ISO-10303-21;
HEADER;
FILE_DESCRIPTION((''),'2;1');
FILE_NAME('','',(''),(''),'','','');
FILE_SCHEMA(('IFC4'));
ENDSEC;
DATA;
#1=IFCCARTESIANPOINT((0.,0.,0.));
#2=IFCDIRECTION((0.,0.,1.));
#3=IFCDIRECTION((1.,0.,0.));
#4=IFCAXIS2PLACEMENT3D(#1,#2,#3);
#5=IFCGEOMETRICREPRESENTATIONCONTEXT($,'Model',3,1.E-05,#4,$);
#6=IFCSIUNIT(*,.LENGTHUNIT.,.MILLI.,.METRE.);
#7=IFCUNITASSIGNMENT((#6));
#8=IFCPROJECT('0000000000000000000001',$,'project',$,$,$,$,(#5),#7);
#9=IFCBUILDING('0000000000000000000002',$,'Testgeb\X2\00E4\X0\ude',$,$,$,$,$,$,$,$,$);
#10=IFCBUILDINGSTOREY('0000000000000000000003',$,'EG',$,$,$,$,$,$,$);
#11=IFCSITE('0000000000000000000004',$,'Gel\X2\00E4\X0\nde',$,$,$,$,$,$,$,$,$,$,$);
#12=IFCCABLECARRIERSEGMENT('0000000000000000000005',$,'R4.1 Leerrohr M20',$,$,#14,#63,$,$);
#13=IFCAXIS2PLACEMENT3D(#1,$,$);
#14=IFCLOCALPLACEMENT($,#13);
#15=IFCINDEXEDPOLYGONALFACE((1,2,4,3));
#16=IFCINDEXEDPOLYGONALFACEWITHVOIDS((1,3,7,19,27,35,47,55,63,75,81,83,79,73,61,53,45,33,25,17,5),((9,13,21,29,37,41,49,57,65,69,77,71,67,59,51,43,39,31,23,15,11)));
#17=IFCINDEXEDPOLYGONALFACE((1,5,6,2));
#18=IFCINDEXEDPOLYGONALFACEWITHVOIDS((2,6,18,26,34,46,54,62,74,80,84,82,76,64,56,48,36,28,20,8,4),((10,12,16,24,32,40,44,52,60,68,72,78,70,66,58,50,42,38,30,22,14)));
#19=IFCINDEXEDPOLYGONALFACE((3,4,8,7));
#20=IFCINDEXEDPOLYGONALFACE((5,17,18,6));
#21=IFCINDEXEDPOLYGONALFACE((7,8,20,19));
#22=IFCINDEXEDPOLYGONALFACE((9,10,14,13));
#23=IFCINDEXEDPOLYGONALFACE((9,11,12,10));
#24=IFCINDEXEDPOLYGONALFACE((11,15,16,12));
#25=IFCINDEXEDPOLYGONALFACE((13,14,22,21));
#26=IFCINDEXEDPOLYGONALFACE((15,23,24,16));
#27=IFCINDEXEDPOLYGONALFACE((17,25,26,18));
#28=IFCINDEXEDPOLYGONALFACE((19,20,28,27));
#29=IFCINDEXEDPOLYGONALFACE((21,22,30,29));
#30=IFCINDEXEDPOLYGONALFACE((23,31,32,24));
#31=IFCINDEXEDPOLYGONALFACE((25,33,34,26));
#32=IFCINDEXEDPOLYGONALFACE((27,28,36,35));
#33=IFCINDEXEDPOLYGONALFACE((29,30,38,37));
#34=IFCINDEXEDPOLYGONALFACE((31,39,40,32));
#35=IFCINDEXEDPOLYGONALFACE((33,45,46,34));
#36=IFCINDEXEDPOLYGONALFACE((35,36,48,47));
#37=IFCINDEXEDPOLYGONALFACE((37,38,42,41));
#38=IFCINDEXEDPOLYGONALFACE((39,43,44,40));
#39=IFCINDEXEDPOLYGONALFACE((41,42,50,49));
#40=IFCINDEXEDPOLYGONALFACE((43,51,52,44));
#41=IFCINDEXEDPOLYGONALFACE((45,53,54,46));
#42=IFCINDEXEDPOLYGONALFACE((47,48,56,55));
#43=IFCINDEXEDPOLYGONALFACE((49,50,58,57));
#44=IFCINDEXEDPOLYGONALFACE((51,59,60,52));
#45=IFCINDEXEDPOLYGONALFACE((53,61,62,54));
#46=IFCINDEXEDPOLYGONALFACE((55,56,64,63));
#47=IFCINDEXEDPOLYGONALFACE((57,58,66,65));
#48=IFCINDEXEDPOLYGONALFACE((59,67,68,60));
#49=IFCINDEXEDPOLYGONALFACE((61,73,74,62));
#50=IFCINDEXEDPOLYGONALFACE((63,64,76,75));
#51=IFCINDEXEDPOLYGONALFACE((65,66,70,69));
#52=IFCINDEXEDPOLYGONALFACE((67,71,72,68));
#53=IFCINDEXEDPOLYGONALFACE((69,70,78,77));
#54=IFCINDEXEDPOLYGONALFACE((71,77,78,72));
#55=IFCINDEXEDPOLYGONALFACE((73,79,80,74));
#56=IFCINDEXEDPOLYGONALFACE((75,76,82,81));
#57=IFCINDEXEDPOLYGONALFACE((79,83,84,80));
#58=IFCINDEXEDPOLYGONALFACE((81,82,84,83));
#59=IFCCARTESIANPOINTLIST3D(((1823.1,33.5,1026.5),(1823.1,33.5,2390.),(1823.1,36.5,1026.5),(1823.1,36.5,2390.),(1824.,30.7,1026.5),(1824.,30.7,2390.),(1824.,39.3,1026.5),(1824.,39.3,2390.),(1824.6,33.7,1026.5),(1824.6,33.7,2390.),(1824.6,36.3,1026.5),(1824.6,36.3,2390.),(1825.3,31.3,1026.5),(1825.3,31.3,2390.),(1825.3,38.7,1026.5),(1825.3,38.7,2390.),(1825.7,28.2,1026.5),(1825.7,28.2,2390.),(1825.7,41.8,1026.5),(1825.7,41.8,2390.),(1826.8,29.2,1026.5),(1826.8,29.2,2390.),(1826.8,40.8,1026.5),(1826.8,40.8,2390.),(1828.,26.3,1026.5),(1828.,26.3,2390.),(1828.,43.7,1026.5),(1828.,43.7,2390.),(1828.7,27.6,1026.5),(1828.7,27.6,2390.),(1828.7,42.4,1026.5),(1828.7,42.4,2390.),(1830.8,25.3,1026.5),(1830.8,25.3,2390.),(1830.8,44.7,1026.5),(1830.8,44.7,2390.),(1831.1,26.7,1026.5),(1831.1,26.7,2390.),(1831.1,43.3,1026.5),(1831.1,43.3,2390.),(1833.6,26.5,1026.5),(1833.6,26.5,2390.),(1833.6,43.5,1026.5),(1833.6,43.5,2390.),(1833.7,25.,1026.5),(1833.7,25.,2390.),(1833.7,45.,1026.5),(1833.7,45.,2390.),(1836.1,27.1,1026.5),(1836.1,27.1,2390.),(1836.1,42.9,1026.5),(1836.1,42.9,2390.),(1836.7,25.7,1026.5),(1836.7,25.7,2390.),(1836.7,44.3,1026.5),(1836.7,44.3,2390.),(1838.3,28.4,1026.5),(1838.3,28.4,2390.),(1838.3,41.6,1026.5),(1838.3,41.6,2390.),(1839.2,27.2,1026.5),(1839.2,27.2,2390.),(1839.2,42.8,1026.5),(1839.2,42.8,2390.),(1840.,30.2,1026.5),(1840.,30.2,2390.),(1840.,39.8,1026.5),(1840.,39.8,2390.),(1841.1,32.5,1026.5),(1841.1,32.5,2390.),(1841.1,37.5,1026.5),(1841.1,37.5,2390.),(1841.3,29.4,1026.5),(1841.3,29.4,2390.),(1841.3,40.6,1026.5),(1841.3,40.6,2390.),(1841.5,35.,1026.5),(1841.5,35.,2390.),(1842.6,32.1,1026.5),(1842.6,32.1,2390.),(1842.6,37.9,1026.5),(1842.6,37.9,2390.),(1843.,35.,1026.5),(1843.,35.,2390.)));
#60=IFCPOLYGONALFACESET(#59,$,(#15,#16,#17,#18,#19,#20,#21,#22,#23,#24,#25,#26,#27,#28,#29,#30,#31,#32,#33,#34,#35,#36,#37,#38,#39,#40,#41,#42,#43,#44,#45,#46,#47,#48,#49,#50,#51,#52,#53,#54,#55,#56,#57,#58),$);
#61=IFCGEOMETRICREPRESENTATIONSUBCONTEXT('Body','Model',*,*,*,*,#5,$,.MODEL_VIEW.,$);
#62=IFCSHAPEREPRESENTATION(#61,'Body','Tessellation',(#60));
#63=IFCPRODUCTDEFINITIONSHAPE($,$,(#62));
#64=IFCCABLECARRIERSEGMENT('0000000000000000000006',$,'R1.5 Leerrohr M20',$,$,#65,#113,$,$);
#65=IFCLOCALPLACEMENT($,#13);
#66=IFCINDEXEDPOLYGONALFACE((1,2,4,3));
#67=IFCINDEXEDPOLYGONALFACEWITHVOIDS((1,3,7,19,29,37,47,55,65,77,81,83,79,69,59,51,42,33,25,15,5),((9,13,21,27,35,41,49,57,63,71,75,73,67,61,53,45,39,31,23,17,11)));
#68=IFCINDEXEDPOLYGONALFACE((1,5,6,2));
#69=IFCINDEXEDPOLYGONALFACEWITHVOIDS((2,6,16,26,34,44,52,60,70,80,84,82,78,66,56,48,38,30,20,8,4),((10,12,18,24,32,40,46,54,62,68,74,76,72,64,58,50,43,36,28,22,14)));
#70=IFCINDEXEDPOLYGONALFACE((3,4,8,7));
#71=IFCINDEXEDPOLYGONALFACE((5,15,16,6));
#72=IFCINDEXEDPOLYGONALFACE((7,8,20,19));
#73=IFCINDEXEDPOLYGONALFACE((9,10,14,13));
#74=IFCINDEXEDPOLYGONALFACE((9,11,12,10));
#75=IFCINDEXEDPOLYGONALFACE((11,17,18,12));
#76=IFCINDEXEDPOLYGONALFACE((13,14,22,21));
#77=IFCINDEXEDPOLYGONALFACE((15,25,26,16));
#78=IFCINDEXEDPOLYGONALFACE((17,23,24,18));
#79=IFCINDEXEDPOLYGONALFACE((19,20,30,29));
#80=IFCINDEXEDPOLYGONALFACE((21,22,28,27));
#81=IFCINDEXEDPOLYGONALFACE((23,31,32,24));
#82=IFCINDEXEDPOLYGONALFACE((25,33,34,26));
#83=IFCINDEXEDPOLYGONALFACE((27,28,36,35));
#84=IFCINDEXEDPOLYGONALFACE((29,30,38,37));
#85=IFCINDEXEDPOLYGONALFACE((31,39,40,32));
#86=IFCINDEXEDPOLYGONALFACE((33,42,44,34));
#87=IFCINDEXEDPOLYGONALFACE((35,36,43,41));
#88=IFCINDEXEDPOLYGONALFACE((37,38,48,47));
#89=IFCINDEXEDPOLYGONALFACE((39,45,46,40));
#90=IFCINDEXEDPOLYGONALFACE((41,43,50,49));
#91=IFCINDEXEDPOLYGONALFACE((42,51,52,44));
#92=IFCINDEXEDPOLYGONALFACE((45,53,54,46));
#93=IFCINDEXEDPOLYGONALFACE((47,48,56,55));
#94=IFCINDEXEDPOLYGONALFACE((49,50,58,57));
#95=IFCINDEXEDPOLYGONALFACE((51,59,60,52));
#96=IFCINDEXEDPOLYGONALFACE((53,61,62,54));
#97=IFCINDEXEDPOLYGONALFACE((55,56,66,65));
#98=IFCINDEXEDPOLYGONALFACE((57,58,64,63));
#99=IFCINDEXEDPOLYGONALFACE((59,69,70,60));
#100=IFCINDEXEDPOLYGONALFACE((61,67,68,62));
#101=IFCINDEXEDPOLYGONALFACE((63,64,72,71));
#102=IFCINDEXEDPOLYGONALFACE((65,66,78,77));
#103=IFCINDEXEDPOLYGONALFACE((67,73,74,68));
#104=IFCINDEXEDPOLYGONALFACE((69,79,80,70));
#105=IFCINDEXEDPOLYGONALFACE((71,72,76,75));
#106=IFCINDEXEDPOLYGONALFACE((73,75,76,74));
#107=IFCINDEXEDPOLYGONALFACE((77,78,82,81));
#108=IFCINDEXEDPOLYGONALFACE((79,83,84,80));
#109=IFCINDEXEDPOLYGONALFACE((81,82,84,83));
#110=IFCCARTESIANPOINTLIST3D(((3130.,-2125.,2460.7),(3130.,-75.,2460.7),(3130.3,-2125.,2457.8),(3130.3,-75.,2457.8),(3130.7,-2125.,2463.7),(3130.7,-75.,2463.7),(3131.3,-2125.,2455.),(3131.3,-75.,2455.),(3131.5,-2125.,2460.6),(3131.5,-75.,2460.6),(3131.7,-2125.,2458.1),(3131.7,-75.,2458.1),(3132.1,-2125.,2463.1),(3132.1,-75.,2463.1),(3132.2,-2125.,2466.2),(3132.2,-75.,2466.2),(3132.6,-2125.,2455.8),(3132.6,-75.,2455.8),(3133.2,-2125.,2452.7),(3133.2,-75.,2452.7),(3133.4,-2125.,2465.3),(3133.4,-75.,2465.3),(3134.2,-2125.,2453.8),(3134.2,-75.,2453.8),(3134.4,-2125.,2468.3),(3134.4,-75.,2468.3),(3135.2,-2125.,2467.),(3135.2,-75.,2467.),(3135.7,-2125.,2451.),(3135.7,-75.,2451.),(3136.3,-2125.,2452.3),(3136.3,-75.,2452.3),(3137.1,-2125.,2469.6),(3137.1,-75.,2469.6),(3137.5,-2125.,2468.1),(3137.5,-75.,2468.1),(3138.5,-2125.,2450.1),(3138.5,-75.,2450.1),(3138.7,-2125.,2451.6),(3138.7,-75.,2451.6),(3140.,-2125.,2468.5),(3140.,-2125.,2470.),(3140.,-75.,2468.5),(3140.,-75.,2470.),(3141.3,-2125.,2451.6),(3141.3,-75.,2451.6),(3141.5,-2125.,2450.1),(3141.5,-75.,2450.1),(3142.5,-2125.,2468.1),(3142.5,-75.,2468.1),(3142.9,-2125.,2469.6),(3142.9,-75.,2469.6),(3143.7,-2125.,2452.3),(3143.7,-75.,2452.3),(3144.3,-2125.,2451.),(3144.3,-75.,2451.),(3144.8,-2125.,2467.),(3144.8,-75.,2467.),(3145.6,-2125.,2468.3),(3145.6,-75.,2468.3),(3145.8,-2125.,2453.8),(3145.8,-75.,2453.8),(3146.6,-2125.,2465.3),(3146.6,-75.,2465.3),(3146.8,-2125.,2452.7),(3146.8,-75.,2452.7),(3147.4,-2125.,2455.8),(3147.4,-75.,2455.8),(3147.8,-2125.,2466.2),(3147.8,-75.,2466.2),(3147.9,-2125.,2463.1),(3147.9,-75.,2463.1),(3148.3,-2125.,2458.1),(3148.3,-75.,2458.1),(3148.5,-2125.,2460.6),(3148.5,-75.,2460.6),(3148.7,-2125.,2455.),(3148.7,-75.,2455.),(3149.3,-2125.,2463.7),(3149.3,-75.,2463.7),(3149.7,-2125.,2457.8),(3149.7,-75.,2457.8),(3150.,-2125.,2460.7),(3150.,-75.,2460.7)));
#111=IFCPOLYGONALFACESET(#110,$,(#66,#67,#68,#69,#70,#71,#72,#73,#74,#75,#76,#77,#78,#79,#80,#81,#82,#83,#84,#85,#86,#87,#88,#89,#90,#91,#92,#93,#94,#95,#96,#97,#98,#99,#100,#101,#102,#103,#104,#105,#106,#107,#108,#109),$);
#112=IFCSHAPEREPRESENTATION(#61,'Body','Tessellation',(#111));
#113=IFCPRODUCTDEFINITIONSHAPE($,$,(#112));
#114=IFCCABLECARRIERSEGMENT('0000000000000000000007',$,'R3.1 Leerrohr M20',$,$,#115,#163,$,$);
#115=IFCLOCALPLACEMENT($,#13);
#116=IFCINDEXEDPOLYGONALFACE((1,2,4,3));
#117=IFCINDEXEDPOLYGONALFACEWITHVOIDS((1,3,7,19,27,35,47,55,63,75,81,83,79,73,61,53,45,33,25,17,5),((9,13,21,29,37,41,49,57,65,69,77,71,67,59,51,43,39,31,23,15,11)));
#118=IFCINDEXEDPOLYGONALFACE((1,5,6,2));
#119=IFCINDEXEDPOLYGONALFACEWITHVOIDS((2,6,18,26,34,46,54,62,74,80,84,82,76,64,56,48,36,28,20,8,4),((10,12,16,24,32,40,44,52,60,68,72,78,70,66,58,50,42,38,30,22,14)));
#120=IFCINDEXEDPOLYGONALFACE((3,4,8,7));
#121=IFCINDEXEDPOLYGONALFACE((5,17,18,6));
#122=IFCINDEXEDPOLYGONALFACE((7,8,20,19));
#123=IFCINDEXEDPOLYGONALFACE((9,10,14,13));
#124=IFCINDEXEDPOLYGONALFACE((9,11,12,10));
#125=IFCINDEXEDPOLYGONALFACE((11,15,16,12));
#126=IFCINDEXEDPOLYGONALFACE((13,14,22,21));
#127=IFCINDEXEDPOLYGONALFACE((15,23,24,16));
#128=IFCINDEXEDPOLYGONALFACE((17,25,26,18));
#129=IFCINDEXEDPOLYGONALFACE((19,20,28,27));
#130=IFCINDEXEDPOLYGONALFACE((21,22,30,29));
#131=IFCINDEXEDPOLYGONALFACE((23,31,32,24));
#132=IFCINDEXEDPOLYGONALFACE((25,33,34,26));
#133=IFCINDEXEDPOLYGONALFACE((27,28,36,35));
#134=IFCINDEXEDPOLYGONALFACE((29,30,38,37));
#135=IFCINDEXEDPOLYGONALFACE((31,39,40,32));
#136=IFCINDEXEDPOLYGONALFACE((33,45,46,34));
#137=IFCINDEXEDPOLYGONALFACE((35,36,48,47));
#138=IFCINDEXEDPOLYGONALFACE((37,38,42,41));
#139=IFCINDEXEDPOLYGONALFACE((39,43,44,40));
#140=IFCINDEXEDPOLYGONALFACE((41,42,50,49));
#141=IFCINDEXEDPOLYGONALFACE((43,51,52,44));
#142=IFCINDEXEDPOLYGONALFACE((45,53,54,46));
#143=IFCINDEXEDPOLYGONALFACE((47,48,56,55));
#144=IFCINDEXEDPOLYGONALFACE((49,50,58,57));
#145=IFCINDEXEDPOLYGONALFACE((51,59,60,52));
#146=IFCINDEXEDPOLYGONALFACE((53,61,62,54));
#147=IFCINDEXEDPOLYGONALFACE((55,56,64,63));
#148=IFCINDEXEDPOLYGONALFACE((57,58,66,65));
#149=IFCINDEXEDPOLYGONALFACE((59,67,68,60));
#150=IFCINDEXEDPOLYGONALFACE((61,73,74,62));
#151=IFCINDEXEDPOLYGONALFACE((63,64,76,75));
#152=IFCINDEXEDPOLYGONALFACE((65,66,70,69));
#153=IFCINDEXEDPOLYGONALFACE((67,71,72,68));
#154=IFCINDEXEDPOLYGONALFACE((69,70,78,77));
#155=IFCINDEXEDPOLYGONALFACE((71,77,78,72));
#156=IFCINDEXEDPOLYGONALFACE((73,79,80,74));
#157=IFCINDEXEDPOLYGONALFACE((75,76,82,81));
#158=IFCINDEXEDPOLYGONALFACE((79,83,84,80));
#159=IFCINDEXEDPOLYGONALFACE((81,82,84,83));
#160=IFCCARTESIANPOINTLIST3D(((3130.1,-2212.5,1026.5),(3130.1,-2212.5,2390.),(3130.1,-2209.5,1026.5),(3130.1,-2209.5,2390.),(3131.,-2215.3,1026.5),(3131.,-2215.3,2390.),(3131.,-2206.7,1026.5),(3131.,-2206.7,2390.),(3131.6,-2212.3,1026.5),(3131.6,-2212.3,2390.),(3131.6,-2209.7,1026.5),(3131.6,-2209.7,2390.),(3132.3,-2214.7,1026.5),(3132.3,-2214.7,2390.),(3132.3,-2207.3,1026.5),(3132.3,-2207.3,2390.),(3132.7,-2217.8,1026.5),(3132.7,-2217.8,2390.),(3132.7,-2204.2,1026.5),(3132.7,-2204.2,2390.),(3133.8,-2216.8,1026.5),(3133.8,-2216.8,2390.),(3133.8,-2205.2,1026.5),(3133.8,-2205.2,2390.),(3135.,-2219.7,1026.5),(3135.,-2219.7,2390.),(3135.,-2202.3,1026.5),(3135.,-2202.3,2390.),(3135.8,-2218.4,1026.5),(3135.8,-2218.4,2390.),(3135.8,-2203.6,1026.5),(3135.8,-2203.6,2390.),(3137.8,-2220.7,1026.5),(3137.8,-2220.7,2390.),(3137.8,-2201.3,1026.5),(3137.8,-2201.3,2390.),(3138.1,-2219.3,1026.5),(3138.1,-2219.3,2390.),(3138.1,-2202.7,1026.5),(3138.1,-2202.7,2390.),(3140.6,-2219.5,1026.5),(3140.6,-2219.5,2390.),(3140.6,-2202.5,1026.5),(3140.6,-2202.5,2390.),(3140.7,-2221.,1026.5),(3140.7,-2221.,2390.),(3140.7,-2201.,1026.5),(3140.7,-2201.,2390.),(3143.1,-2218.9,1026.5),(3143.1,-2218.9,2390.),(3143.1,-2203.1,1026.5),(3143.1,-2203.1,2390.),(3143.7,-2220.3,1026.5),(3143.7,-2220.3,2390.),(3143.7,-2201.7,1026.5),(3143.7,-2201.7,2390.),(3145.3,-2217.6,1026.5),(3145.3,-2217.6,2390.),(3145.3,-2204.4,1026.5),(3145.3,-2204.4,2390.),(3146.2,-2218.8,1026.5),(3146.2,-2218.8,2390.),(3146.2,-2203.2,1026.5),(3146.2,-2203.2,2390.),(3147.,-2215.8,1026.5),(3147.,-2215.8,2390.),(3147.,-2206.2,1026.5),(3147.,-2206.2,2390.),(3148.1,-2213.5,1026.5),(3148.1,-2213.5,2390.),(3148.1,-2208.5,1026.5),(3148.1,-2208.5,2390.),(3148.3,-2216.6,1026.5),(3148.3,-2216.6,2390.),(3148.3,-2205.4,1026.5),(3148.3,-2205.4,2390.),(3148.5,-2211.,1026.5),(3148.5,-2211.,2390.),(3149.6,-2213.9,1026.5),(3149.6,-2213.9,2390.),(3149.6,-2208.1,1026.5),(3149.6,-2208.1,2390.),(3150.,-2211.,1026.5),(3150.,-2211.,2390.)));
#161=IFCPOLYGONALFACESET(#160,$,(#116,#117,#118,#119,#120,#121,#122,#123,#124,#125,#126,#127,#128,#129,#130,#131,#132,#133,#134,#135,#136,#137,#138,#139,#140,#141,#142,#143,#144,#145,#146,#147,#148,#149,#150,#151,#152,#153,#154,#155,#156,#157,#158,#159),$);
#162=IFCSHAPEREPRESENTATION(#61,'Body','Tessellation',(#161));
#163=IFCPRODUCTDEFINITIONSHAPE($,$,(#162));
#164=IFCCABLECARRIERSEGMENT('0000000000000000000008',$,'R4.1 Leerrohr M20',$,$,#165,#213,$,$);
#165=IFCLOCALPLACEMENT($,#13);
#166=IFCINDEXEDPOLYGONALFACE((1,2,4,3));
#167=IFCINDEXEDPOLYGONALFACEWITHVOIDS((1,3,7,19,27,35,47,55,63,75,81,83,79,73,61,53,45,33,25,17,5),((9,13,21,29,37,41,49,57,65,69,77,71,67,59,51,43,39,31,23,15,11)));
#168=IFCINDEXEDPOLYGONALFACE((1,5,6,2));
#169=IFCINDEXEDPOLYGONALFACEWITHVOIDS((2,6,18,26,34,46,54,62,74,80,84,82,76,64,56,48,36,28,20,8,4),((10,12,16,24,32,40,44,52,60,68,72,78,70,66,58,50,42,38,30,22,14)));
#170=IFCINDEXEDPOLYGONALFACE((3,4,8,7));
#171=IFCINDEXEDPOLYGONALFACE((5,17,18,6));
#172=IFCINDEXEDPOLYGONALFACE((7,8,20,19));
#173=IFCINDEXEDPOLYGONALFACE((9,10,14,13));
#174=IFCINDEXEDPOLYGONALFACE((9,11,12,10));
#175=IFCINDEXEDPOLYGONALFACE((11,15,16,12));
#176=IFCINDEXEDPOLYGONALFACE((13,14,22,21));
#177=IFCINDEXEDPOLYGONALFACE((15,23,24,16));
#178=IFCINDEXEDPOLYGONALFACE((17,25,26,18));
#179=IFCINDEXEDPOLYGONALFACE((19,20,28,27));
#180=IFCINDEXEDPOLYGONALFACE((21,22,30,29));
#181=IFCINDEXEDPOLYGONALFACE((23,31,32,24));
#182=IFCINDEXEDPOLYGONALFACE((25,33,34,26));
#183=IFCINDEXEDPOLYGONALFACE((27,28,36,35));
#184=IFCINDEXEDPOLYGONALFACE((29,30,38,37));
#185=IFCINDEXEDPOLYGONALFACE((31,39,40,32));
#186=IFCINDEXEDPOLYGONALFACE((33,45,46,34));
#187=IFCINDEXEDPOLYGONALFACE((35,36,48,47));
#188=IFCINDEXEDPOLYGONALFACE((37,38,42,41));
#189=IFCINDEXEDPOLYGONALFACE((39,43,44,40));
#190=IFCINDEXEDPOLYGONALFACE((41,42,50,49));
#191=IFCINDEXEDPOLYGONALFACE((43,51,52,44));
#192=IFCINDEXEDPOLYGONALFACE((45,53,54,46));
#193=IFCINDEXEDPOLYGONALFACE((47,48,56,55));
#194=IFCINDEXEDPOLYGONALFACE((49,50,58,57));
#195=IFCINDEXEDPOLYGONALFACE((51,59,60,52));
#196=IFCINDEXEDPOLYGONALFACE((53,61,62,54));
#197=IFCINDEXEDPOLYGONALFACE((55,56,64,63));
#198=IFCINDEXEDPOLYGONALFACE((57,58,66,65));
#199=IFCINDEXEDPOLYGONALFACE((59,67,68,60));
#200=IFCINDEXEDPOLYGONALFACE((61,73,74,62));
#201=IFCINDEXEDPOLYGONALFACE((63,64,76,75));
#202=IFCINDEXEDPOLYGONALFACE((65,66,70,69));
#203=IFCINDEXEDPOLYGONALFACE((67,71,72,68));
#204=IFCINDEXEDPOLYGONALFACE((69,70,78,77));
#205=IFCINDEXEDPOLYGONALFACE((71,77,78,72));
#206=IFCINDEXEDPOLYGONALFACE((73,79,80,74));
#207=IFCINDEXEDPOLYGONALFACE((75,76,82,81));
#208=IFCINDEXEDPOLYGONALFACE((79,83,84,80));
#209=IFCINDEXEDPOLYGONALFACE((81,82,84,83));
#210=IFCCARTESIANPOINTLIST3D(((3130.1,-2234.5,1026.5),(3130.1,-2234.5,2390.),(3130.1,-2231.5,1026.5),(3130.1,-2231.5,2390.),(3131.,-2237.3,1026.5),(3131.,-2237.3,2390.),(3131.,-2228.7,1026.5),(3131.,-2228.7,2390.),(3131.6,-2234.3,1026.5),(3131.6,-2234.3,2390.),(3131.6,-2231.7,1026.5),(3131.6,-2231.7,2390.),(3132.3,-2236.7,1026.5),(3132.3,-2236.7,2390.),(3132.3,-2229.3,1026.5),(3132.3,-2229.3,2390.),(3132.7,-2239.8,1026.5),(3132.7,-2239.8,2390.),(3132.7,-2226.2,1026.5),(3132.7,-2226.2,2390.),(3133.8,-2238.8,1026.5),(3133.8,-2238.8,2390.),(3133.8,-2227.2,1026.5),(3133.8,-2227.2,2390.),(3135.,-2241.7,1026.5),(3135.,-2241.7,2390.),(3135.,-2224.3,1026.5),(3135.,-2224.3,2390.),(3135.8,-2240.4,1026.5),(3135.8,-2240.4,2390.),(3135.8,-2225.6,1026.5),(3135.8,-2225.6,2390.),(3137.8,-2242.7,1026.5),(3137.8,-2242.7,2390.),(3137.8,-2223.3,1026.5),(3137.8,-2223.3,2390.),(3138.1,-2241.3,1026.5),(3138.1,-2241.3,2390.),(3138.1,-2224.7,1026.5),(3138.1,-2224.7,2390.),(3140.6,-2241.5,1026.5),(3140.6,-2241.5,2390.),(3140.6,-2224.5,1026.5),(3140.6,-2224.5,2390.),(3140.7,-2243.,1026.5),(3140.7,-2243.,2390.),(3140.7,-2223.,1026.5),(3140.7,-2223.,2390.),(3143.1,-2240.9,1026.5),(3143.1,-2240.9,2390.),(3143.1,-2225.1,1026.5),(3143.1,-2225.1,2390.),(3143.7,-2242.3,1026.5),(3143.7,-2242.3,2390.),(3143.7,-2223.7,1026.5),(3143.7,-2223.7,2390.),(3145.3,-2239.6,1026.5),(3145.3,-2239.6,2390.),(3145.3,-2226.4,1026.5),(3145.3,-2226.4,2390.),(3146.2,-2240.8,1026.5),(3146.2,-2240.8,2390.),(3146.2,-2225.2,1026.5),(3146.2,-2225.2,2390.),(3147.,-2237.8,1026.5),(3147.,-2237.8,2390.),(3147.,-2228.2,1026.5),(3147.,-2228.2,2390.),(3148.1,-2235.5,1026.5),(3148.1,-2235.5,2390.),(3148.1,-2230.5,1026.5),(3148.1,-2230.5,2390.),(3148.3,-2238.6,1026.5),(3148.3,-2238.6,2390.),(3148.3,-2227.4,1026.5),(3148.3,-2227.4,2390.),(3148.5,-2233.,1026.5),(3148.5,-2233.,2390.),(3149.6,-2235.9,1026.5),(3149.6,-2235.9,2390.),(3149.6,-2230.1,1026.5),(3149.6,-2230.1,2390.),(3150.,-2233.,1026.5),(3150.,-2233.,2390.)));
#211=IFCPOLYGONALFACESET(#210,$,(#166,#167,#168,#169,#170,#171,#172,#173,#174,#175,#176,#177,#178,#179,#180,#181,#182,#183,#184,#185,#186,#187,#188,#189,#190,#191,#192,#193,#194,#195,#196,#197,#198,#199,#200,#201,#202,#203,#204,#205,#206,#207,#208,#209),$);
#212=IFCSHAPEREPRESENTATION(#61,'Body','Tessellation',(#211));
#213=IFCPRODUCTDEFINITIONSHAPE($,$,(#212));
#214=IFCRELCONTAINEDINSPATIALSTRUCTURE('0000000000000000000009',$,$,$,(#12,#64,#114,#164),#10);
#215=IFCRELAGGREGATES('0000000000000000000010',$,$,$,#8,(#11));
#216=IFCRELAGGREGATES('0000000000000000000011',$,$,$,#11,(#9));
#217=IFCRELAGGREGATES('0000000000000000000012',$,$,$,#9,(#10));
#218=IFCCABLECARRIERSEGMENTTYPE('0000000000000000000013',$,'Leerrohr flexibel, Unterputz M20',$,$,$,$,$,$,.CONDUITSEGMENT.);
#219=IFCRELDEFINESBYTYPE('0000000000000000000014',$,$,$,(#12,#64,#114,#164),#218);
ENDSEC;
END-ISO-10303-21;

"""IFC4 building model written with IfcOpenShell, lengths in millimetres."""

from ifc_helpers import new_model, si_unit, frame, origin_with_axes, place, context, subcontext, project, spatial, hollow_circle, extrude, type_object, element, save


model = new_model("IFC4")

# Units and contexts
model_context = context("Model", 3, precision=1e-05, world=origin_with_axes())
body_context = subcontext(model_context, "Body", "Model", "MODEL_VIEW")
ifc_project = project(units=[si_unit("LENGTHUNIT", "METRE", prefix="MILLI")], contexts=[model_context])

# Site, building, storey
site = spatial("IfcSite", under=ifc_project, Name="Gelände")
building = spatial("IfcBuilding", under=site, Name="Testgebäude")
storey = spatial("IfcBuildingStorey", under=building, Name="EG")

# Cable carrier segments
cable_carrier_segment_type_1 = type_object("IfcCableCarrierSegmentType", Name="Leerrohr flexibel, Unterputz M20", PredefinedType="CONDUITSEGMENT")
for number, where, z_axis, x_axis, name in (
    (1, (1833.0, 35.0, 1026.5), (0.0, 0.0, 1.0), (1.0, 0.0, 0.0), "R4.1 Leerrohr M20"),
):
    element("IfcCableCarrierSegment", number, at=place(None, frame(where, z_axis=z_axis, x_axis=x_axis)), inside=storey, type_object=cable_carrier_segment_type_1, Name=name, context=body_context, shape_type="SweptSolid", body=[
        extrude(hollow_circle(Radius=10.0, WallThickness=1.5), None, (0.0, 0.0, 1.0), 1363.5),
    ])
cable_carrier_segment_1_placement = place(None, frame((3140.0, -75.0, 2460.0), z_axis=(0.0, -1.0, 0.0), x_axis=(0.0, 0.0, 1.0)))
element("IfcCableCarrierSegment", 2, at=cable_carrier_segment_1_placement, inside=storey, type_object=cable_carrier_segment_type_1, Name="R1.5 Leerrohr M20", context=body_context, shape_type="SweptSolid", body=[
    extrude(hollow_circle(Radius=10.0, WallThickness=1.5), None, (0.0, 0.0, 1.0), 2050.0),
])
for number, where, z_axis, x_axis, name in (
    (3, (3140.0, -2211.0, 1026.5), (0.0, 0.0, 1.0), (1.0, 0.0, 0.0), "R3.1 Leerrohr M20"),
    (4, (3140.0, -2233.0, 1026.5), (0.0, 0.0, 1.0), (1.0, 0.0, 0.0), "R4.1 Leerrohr M20"),
):
    element("IfcCableCarrierSegment", number, at=place(None, frame(where, z_axis=z_axis, x_axis=x_axis)), inside=storey, type_object=cable_carrier_segment_type_1, Name=name, context=body_context, shape_type="SweptSolid", body=[
        extrude(hollow_circle(Radius=10.0, WallThickness=1.5), None, (0.0, 0.0, 1.0), 1363.5),
    ])

save(model, "model.ifc")
